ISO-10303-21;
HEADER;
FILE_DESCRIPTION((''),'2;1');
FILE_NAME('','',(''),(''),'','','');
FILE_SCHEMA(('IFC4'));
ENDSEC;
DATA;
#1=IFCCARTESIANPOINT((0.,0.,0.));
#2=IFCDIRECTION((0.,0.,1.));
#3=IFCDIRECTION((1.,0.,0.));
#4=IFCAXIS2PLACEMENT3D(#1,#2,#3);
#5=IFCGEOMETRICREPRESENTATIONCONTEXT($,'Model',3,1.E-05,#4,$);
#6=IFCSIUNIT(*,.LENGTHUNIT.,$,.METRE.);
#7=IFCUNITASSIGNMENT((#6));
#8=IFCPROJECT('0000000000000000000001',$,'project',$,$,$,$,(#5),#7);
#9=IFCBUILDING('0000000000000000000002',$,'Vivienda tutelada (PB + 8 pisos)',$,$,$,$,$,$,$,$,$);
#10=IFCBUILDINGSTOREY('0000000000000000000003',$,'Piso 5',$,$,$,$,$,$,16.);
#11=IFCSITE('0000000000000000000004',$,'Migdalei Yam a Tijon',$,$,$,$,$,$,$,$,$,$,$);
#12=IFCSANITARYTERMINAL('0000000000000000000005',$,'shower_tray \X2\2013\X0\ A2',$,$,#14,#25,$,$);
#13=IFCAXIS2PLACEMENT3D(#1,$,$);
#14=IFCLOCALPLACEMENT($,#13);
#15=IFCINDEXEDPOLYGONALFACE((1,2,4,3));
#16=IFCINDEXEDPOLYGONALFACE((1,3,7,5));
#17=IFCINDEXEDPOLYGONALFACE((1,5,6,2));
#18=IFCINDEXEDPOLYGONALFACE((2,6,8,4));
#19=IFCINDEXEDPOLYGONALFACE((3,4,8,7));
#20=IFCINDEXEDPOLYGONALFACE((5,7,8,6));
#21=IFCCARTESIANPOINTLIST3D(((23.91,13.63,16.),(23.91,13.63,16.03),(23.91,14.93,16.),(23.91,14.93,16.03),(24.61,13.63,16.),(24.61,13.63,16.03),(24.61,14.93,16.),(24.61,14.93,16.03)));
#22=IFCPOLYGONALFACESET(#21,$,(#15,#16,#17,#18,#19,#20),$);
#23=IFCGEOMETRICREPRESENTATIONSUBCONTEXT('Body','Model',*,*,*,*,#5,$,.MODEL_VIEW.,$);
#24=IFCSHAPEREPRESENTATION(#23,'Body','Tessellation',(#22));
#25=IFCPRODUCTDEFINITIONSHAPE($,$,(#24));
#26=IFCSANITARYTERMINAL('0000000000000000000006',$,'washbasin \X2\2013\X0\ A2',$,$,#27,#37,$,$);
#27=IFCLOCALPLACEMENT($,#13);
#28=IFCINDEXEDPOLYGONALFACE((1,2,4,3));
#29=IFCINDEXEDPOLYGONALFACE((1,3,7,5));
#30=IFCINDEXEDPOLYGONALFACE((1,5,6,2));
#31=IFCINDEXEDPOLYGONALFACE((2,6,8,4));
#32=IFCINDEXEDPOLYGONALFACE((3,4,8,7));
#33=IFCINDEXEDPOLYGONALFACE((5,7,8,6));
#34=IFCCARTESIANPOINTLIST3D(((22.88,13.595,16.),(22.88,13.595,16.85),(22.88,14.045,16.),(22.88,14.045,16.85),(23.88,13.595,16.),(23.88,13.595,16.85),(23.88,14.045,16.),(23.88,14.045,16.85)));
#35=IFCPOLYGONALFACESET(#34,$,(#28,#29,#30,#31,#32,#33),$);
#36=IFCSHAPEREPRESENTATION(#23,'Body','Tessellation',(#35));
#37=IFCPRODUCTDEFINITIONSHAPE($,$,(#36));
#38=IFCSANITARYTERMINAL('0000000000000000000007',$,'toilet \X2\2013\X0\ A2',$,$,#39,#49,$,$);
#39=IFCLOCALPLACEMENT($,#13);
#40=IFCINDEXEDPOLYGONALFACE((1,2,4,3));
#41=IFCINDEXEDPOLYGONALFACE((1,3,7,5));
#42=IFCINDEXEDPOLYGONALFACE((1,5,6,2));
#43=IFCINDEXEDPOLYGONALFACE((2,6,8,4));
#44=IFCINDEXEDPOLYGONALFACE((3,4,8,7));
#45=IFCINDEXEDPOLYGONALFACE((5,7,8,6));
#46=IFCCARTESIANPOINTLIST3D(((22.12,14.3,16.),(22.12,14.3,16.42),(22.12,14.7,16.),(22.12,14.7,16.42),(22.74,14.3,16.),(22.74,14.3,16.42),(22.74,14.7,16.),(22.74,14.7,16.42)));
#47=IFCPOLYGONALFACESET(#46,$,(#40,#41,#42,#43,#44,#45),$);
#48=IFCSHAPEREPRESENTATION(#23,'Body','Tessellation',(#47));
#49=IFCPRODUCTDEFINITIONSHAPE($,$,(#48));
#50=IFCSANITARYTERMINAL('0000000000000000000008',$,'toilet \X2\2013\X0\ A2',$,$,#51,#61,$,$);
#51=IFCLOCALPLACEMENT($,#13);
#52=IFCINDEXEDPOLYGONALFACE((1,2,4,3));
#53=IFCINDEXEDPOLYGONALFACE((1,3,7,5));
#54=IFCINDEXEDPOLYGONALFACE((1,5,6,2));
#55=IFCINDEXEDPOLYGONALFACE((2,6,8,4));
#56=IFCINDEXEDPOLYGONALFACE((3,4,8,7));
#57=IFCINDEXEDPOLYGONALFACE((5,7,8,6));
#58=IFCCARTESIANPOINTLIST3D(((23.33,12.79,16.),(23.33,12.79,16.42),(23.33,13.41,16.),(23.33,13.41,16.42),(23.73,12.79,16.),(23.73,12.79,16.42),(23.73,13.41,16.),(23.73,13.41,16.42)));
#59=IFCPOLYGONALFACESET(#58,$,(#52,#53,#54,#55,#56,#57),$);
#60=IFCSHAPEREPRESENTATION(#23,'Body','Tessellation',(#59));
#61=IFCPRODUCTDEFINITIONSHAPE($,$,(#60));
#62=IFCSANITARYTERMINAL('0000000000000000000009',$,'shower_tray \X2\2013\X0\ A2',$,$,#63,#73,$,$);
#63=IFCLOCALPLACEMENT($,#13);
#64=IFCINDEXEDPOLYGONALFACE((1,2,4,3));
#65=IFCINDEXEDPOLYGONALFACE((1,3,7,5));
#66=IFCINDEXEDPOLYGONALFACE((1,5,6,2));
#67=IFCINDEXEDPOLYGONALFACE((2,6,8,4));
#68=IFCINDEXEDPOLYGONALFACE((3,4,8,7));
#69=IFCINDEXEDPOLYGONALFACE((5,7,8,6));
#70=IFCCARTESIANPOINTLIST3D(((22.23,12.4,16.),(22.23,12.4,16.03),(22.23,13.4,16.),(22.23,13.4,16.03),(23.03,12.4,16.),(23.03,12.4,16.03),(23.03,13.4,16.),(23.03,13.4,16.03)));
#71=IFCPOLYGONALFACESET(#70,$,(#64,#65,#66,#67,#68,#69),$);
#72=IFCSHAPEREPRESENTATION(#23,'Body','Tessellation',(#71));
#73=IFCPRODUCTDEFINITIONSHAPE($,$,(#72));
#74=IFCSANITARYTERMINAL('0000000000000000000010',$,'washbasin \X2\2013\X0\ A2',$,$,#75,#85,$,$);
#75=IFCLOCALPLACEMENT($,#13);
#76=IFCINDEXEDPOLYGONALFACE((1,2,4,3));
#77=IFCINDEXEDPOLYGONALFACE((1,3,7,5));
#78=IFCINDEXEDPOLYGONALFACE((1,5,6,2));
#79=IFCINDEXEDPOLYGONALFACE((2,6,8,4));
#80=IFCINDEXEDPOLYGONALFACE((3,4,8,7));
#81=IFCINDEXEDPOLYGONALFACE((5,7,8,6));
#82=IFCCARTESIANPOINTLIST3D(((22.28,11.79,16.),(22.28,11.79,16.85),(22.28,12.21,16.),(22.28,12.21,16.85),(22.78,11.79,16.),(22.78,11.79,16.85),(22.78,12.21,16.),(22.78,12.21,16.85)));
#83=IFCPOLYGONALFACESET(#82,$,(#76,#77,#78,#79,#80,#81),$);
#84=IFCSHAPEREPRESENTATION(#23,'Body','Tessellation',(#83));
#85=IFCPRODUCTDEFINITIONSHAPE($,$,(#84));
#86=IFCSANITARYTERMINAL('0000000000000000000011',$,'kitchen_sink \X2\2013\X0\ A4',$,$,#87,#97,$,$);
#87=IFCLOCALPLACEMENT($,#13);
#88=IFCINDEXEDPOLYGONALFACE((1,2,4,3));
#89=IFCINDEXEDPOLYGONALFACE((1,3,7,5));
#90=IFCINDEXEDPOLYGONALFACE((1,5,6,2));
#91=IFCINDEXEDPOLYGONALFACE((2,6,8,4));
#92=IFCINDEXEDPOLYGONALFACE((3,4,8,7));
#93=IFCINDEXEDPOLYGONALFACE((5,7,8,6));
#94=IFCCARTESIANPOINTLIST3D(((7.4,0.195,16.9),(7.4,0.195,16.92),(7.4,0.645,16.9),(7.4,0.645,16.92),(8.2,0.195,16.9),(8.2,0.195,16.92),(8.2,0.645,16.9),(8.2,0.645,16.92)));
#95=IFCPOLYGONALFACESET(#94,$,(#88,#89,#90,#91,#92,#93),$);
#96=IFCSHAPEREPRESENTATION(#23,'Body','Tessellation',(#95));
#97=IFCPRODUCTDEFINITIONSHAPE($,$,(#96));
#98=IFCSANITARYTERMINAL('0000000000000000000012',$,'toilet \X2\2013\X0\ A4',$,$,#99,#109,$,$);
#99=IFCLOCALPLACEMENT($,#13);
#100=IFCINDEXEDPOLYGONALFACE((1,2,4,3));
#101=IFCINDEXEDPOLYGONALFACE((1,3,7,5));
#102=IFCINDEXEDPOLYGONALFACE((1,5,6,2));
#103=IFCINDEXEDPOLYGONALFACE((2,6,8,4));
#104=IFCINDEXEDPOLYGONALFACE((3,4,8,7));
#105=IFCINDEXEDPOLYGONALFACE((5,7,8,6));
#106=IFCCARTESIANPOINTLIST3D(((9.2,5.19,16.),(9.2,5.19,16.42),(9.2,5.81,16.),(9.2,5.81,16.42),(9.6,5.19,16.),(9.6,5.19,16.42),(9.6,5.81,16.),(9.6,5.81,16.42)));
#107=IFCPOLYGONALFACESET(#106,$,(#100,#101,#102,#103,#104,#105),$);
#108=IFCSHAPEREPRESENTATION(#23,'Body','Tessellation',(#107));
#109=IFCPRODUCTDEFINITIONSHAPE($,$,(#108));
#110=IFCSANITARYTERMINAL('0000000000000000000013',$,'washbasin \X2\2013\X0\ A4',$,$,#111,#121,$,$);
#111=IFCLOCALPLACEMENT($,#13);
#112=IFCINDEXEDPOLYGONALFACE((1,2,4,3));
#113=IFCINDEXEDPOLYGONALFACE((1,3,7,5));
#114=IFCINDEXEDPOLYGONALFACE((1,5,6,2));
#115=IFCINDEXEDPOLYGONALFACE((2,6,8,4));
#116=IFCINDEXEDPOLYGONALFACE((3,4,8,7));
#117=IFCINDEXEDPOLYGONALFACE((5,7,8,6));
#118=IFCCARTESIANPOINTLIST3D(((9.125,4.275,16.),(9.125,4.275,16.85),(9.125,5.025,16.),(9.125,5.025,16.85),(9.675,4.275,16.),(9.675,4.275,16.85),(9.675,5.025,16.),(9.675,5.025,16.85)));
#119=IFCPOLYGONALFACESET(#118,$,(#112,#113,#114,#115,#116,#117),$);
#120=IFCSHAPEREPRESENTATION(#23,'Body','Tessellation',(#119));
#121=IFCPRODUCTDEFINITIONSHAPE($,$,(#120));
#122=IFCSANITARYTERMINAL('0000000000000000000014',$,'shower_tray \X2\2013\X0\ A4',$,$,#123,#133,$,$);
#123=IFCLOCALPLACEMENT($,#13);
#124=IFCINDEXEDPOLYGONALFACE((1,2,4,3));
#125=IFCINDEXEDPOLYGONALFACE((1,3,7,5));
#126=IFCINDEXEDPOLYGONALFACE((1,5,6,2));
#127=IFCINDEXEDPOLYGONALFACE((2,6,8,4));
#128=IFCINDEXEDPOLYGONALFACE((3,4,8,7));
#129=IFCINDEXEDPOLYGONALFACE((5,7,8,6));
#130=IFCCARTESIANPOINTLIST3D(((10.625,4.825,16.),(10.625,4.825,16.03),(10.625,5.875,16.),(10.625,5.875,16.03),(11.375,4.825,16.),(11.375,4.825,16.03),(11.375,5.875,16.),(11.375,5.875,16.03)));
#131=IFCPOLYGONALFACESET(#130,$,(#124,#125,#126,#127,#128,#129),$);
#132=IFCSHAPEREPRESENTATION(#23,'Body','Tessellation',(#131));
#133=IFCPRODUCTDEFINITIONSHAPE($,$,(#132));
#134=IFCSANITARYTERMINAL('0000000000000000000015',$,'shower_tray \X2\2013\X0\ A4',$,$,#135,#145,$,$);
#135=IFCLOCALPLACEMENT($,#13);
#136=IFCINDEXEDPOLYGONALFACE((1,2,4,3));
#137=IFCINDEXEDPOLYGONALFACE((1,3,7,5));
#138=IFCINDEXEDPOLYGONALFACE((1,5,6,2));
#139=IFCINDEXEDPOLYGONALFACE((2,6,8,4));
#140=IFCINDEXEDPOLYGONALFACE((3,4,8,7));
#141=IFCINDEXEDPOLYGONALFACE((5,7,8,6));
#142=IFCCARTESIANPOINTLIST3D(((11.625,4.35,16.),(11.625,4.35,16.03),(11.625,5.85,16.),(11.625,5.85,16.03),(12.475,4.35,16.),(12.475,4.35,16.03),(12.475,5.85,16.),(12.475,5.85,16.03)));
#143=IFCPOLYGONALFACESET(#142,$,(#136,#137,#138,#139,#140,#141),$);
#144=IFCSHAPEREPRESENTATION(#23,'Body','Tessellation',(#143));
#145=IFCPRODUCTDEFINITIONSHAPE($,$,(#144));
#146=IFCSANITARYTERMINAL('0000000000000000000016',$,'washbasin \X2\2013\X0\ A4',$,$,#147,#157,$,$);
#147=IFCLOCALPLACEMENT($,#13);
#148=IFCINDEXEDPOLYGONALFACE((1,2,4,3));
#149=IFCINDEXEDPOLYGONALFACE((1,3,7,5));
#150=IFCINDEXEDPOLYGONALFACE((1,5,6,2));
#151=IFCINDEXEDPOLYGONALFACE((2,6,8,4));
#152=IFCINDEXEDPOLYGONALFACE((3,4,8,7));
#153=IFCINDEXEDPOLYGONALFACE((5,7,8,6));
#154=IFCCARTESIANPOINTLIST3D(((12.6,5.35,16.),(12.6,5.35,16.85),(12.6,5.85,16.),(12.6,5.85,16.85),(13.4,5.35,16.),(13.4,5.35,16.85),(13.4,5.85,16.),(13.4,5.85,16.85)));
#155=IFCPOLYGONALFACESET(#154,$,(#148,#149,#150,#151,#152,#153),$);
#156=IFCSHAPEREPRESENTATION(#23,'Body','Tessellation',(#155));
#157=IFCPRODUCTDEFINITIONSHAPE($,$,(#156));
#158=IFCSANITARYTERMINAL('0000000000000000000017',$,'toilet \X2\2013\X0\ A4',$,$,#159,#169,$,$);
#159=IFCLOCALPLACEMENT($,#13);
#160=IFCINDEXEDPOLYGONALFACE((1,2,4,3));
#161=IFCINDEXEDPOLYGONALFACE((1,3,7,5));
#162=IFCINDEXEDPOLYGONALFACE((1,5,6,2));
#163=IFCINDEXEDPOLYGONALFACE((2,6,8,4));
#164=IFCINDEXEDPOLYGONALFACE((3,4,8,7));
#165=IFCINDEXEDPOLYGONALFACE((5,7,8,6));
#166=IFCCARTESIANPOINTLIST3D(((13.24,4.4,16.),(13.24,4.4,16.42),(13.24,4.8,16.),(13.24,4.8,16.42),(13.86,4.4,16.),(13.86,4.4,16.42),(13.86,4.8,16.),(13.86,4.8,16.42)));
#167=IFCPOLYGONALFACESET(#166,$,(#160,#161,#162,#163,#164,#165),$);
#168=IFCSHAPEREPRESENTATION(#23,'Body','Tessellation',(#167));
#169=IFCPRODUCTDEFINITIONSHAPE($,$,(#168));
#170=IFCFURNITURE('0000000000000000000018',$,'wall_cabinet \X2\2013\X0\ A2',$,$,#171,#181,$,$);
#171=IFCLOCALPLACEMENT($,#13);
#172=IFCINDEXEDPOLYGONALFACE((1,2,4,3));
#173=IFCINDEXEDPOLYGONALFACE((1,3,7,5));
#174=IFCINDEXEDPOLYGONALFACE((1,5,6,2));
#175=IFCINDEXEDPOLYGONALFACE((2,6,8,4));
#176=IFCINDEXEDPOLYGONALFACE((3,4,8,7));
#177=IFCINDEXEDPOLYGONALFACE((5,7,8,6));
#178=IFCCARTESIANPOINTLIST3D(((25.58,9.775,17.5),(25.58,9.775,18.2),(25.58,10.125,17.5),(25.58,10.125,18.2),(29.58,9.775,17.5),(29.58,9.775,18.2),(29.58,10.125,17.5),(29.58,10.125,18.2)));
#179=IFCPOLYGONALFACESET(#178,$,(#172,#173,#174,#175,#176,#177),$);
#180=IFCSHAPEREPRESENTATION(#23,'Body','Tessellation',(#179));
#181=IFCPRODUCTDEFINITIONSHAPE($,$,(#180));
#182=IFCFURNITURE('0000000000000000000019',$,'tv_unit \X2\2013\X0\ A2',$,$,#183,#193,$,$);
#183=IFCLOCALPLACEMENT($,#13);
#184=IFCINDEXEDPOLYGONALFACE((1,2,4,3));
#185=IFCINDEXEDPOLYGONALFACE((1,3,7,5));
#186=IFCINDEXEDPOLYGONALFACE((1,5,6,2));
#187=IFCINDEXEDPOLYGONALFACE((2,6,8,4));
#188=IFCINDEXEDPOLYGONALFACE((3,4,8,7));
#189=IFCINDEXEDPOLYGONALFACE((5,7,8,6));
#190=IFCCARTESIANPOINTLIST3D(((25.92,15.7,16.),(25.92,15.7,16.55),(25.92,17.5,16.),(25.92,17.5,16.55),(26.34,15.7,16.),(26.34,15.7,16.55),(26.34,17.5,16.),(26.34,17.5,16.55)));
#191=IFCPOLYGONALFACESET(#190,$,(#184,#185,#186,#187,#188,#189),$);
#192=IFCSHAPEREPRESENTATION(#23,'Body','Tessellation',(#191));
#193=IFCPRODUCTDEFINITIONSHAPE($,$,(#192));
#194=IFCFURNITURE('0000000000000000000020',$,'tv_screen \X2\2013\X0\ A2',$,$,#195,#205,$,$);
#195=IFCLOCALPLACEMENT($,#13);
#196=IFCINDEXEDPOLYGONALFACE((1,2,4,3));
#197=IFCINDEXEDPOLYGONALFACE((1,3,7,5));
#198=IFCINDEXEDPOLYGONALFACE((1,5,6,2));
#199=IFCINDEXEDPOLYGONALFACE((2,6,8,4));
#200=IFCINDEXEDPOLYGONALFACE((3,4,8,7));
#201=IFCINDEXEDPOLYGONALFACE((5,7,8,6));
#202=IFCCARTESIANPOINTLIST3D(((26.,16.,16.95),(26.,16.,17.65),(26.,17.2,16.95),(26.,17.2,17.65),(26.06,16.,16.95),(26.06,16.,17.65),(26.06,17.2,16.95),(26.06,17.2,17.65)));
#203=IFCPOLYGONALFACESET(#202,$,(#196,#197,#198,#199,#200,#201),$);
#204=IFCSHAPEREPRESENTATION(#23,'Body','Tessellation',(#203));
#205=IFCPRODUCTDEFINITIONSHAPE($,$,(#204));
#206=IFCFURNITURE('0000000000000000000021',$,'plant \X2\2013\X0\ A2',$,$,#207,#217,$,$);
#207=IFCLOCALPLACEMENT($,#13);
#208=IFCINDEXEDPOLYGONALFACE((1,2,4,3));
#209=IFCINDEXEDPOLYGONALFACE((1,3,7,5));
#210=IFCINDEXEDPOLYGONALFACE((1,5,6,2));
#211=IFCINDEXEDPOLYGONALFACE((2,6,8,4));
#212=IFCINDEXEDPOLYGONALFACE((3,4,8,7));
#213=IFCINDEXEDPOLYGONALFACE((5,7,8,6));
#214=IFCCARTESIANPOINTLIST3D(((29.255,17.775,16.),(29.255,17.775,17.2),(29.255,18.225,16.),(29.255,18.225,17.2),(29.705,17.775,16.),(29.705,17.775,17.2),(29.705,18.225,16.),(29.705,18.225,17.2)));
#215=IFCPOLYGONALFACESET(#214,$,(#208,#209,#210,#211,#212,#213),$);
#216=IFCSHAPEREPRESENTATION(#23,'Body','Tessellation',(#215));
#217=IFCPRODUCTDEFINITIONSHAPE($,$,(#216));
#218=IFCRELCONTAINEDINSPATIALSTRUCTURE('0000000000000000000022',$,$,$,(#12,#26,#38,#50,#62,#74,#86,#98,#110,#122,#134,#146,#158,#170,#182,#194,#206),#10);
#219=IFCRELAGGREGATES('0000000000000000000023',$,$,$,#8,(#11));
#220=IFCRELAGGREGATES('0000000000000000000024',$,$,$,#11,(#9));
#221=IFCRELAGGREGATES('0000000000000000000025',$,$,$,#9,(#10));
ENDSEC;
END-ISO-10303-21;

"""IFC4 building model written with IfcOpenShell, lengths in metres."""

from ifc_helpers import new_model, si_unit, frame, origin_with_axes, context, subcontext, project, spatial, line, indexed_curve, outline, extrude, element, save


model = new_model("IFC4")

# Units and contexts
model_context = context("Model", 3, precision=1e-05, world=origin_with_axes())
body_context = subcontext(model_context, "Body", "Model", "MODEL_VIEW")
ifc_project = project(units=[si_unit("LENGTHUNIT", "METRE")], contexts=[model_context])

# Site, building, storey
site = spatial("IfcSite", under=ifc_project, Name="Migdalei Yam a Tijon")
building = spatial("IfcBuilding", under=site, Name="Vivienda tutelada (PB + 8 pisos)")
storey = spatial("IfcBuildingStorey", under=building, Name="Piso 5", Elevation=16.0)

# Sanitary terminals
element("IfcSanitaryTerminal", 1, inside=storey, Name="shower_tray – A2", context=body_context, shape_type="SweptSolid", body=[
    extrude(outline(indexed_curve([(0.0, 0.0), (0.7, 0.0), (0.7, 1.3), (0.0, 1.3)], segments=[line(1, 2, 3, 4, 1)])), frame((23.91, 13.63, 16.0), z_axis=(0.0, 0.0, 1.0), x_axis=(1.0, 0.0, 0.0)), (0.0, 0.0, 1.0), 0.03),
])
element("IfcSanitaryTerminal", 2, inside=storey, Name="washbasin – A2", context=body_context, shape_type="SweptSolid", body=[
    extrude(outline(indexed_curve([(0.0, 0.0), (1.0, 0.0), (1.0, 0.45), (0.0, 0.45)], segments=[line(1, 2, 3, 4, 1)])), frame((22.88, 13.595, 16.0), z_axis=(0.0, 0.0, 1.0), x_axis=(1.0, 0.0, 0.0)), (0.0, 0.0, 1.0), 0.85),
])
element("IfcSanitaryTerminal", 3, inside=storey, Name="toilet – A2", context=body_context, shape_type="SweptSolid", body=[
    extrude(outline(indexed_curve([(0.0, 0.0), (0.62, 0.0), (0.62, 0.4), (0.0, 0.4)], segments=[line(1, 2, 3, 4, 1)])), frame((22.12, 14.3, 16.0), z_axis=(0.0, 0.0, 1.0), x_axis=(1.0, 0.0, 0.0)), (0.0, 0.0, 1.0), 0.42),
])
element("IfcSanitaryTerminal", 4, inside=storey, Name="toilet – A2", context=body_context, shape_type="SweptSolid", body=[
    extrude(outline(indexed_curve([(0.0, 0.0), (0.4, 0.0), (0.4, 0.62), (0.0, 0.62)], segments=[line(1, 2, 3, 4, 1)])), frame((23.33, 12.79, 16.0), z_axis=(0.0, 0.0, 1.0), x_axis=(1.0, 0.0, 0.0)), (0.0, 0.0, 1.0), 0.42),
])
element("IfcSanitaryTerminal", 5, inside=storey, Name="shower_tray – A2", context=body_context, shape_type="SweptSolid", body=[
    extrude(outline(indexed_curve([(0.0, 0.0), (0.8, 0.0), (0.8, 1.0), (0.0, 1.0)], segments=[line(1, 2, 3, 4, 1)])), frame((22.23, 12.4, 16.0), z_axis=(0.0, 0.0, 1.0), x_axis=(1.0, 0.0, 0.0)), (0.0, 0.0, 1.0), 0.03),
])
element("IfcSanitaryTerminal", 6, inside=storey, Name="washbasin – A2", context=body_context, shape_type="SweptSolid", body=[
    extrude(outline(indexed_curve([(0.0, 0.0), (0.5, 0.0), (0.5, 0.42), (0.0, 0.42)], segments=[line(1, 2, 3, 4, 1)])), frame((22.28, 11.79, 16.0), z_axis=(0.0, 0.0, 1.0), x_axis=(1.0, 0.0, 0.0)), (0.0, 0.0, 1.0), 0.85),
])
element("IfcSanitaryTerminal", 7, inside=storey, Name="kitchen_sink – A4", context=body_context, shape_type="SweptSolid", body=[
    extrude(outline(indexed_curve([(0.0, 0.0), (0.8, 0.0), (0.8, 0.45), (0.0, 0.45)], segments=[line(1, 2, 3, 4, 1)])), frame((7.4, 0.195, 16.9), z_axis=(0.0, 0.0, 1.0), x_axis=(1.0, 0.0, 0.0)), (0.0, 0.0, 1.0), 0.02),
])
element("IfcSanitaryTerminal", 8, inside=storey, Name="toilet – A4", context=body_context, shape_type="SweptSolid", body=[
    extrude(outline(indexed_curve([(0.0, 0.0), (0.4, 0.0), (0.4, 0.62), (0.0, 0.62)], segments=[line(1, 2, 3, 4, 1)])), frame((9.2, 5.19, 16.0), z_axis=(0.0, 0.0, 1.0), x_axis=(1.0, 0.0, 0.0)), (0.0, 0.0, 1.0), 0.42),
])
element("IfcSanitaryTerminal", 9, inside=storey, Name="washbasin – A4", context=body_context, shape_type="SweptSolid", body=[
    extrude(outline(indexed_curve([(0.0, 0.0), (0.55, 0.0), (0.55, 0.75), (0.0, 0.75)], segments=[line(1, 2, 3, 4, 1)])), frame((9.125, 4.275, 16.0), z_axis=(0.0, 0.0, 1.0), x_axis=(1.0, 0.0, 0.0)), (0.0, 0.0, 1.0), 0.85),
])
element("IfcSanitaryTerminal", 10, inside=storey, Name="shower_tray – A4", context=body_context, shape_type="SweptSolid", body=[
    extrude(outline(indexed_curve([(0.0, 0.0), (0.75, 0.0), (0.75, 1.05), (0.0, 1.05)], segments=[line(1, 2, 3, 4, 1)])), frame((10.625, 4.825, 16.0), z_axis=(0.0, 0.0, 1.0), x_axis=(1.0, 0.0, 0.0)), (0.0, 0.0, 1.0), 0.03),
])
element("IfcSanitaryTerminal", 11, inside=storey, Name="shower_tray – A4", context=body_context, shape_type="SweptSolid", body=[
    extrude(outline(indexed_curve([(0.0, 0.0), (0.85, 0.0), (0.85, 1.5), (0.0, 1.5)], segments=[line(1, 2, 3, 4, 1)])), frame((11.625, 4.35, 16.0), z_axis=(0.0, 0.0, 1.0), x_axis=(1.0, 0.0, 0.0)), (0.0, 0.0, 1.0), 0.03),
])
element("IfcSanitaryTerminal", 12, inside=storey, Name="washbasin – A4", context=body_context, shape_type="SweptSolid", body=[
    extrude(outline(indexed_curve([(0.0, 0.0), (0.8, 0.0), (0.8, 0.5), (0.0, 0.5)], segments=[line(1, 2, 3, 4, 1)])), frame((12.6, 5.35, 16.0), z_axis=(0.0, 0.0, 1.0), x_axis=(1.0, 0.0, 0.0)), (0.0, 0.0, 1.0), 0.85),
])
element("IfcSanitaryTerminal", 13, inside=storey, Name="toilet – A4", context=body_context, shape_type="SweptSolid", body=[
    extrude(outline(indexed_curve([(0.0, 0.0), (0.62, 0.0), (0.62, 0.4), (0.0, 0.4)], segments=[line(1, 2, 3, 4, 1)])), frame((13.24, 4.4, 16.0), z_axis=(0.0, 0.0, 1.0), x_axis=(1.0, 0.0, 0.0)), (0.0, 0.0, 1.0), 0.42),
])

# Furniture
element("IfcFurniture", 14, inside=storey, Name="wall_cabinet – A2", context=body_context, shape_type="SweptSolid", body=[
    extrude(outline(indexed_curve([(0.0, 0.0), (4.0, 0.0), (4.0, 0.35), (0.0, 0.35)], segments=[line(1, 2, 3, 4, 1)])), frame((25.58, 9.775, 17.5), z_axis=(0.0, 0.0, 1.0), x_axis=(1.0, 0.0, 0.0)), (0.0, 0.0, 1.0), 0.7),
])
element("IfcFurniture", 15, inside=storey, Name="tv_unit – A2", context=body_context, shape_type="SweptSolid", body=[
    extrude(outline(indexed_curve([(0.0, 0.0), (0.42, 0.0), (0.42, 1.8), (0.0, 1.8)], segments=[line(1, 2, 3, 4, 1)])), frame((25.92, 15.7, 16.0), z_axis=(0.0, 0.0, 1.0), x_axis=(1.0, 0.0, 0.0)), (0.0, 0.0, 1.0), 0.55),
])
element("IfcFurniture", 16, inside=storey, Name="tv_screen – A2", context=body_context, shape_type="SweptSolid", body=[
    extrude(outline(indexed_curve([(0.0, 0.0), (0.06, 0.0), (0.06, 1.2), (0.0, 1.2)], segments=[line(1, 2, 3, 4, 1)])), frame((26.0, 16.0, 16.95), z_axis=(0.0, 0.0, 1.0), x_axis=(1.0, 0.0, 0.0)), (0.0, 0.0, 1.0), 0.7),
])
element("IfcFurniture", 17, inside=storey, Name="plant – A2", context=body_context, shape_type="SweptSolid", body=[
    extrude(outline(indexed_curve([(0.0, 0.0), (0.45, 0.0), (0.45, 0.45), (0.0, 0.45)], segments=[line(1, 2, 3, 4, 1)])), frame((29.255, 17.775, 16.0), z_axis=(0.0, 0.0, 1.0), x_axis=(1.0, 0.0, 0.0)), (0.0, 0.0, 1.0), 1.2),
])

save(model, "model.ifc")
